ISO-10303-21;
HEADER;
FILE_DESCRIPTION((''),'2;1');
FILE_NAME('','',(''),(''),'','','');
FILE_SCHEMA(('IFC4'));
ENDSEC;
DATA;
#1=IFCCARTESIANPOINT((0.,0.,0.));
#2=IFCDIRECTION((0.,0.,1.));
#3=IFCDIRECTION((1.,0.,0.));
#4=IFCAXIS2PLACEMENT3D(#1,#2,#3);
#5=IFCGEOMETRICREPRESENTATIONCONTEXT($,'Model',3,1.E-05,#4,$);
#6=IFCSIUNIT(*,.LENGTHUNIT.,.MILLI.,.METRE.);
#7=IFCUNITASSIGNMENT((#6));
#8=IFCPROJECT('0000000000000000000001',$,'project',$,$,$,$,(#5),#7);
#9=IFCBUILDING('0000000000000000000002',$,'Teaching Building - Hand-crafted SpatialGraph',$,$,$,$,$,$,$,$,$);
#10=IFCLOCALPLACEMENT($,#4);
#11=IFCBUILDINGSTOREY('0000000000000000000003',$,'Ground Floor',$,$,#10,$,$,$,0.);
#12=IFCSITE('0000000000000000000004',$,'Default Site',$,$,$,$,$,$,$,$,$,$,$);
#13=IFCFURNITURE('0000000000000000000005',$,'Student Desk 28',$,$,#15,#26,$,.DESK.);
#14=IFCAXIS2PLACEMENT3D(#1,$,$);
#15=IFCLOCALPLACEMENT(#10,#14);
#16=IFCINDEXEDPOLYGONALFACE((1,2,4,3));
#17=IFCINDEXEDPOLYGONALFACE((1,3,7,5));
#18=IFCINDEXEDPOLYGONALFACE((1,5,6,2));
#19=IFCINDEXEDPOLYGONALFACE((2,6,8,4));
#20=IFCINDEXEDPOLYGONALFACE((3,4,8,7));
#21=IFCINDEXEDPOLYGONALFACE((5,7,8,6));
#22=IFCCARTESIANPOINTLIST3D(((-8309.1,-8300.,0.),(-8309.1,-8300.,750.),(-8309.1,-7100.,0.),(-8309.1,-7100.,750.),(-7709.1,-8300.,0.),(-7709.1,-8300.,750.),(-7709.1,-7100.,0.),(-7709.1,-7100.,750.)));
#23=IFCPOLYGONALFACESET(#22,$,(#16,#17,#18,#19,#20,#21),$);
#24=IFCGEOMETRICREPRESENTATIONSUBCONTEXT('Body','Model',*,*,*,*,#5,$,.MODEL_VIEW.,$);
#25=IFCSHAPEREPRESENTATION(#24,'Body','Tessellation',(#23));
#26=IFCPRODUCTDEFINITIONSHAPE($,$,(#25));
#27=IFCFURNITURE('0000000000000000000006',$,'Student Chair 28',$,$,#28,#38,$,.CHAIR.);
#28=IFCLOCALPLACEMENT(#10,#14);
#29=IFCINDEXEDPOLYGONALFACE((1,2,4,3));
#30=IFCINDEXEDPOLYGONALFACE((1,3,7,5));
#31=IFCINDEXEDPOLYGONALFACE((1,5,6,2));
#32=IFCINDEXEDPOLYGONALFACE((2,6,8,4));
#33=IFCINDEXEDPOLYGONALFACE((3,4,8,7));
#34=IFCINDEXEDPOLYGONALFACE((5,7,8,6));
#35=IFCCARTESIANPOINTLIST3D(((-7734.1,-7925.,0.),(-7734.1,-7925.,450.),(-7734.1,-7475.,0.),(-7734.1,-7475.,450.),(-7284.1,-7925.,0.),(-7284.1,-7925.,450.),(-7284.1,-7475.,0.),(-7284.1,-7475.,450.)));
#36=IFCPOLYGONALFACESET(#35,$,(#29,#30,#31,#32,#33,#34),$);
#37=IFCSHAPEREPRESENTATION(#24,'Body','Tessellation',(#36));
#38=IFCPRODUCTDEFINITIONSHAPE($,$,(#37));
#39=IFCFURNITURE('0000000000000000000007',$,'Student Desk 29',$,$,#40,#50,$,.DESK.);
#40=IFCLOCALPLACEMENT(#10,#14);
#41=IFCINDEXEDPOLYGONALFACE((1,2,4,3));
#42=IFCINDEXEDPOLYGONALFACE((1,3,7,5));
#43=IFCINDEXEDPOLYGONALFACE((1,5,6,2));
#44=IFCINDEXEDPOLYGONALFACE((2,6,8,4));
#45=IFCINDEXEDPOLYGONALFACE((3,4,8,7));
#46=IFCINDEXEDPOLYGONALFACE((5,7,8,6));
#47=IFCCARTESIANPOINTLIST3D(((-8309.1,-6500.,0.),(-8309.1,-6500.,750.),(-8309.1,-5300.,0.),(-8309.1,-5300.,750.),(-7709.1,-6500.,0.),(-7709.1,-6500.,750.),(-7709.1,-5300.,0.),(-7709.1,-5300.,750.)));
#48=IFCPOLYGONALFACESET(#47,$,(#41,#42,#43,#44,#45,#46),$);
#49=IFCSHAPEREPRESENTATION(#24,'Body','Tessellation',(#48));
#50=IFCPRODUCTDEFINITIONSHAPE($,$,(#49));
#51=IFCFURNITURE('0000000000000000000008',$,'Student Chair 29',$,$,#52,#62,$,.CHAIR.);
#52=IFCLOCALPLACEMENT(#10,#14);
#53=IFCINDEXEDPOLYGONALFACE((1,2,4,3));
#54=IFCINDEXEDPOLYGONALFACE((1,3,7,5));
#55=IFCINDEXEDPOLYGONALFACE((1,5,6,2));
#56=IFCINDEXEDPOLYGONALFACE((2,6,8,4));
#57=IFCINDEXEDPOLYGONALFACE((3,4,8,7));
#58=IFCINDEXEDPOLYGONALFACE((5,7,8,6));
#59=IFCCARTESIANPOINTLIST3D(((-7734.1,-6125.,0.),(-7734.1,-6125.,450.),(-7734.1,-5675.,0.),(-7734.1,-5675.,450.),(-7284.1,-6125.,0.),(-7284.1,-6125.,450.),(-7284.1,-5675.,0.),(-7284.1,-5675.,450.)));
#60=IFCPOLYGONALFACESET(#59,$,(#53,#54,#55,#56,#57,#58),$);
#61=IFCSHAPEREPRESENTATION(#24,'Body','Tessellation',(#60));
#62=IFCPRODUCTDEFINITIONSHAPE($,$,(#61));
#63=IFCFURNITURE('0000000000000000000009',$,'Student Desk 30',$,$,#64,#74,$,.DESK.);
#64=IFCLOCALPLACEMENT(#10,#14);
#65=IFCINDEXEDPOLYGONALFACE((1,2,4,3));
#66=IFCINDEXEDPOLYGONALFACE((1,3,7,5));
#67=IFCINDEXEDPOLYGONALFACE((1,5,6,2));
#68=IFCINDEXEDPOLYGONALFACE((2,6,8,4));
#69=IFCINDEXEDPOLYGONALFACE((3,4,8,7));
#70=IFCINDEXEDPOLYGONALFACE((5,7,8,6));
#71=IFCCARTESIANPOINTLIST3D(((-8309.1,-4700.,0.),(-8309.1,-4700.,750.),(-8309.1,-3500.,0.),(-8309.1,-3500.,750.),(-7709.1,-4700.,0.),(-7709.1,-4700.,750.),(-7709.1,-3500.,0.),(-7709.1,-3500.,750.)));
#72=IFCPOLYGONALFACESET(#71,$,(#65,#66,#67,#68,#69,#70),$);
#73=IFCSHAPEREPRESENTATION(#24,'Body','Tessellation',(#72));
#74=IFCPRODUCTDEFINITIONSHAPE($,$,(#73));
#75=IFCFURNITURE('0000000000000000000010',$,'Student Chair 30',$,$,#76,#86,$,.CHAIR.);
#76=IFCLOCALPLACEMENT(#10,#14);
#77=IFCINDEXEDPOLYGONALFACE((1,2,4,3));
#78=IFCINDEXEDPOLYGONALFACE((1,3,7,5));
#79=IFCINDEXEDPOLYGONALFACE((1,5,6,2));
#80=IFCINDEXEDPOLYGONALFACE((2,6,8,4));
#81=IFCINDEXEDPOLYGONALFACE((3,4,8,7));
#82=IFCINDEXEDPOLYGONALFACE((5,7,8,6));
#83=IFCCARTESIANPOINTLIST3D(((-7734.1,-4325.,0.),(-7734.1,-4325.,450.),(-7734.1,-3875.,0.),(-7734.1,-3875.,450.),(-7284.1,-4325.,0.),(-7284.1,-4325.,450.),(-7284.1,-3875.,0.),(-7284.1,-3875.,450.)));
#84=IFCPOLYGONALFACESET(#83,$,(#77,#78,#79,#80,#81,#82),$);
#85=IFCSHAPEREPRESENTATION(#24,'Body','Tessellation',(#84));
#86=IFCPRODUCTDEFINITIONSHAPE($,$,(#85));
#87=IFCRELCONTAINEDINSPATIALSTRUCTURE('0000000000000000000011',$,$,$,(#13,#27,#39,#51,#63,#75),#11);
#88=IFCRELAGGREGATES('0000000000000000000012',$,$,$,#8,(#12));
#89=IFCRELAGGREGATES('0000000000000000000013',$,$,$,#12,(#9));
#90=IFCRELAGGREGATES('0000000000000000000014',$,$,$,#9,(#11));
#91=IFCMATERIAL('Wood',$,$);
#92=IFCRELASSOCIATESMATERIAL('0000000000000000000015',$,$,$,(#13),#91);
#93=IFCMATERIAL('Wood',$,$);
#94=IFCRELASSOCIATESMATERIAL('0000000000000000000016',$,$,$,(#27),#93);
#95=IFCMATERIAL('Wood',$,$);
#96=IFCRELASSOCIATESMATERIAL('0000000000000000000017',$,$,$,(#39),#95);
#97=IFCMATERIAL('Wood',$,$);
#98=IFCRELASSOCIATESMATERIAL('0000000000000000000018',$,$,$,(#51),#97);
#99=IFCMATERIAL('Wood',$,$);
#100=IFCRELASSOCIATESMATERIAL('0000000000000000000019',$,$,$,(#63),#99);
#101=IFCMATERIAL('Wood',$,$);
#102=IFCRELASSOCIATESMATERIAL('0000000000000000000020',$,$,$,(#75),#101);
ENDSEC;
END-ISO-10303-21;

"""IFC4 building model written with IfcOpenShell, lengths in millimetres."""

from ifc_helpers import new_model, si_unit, frame, origin_with_axes, origin_2d, place, context, subcontext, project, spatial, rectangle, extrude, material, element, save


model = new_model("IFC4")

# Units and contexts
model_context = context("Model", 3, precision=1e-05, world=origin_with_axes())
body_context = subcontext(model_context, "Body", "Model", "MODEL_VIEW")
ifc_project = project(units=[si_unit("LENGTHUNIT", "METRE", prefix="MILLI")], contexts=[model_context])

# Site, building, storey
site = spatial("IfcSite", under=ifc_project, Name="Default Site")
building = spatial("IfcBuilding", under=site, Name="Teaching Building - Hand-crafted SpatialGraph")
storey_placement = place(None, origin_with_axes())
storey = spatial("IfcBuildingStorey", under=building, at=storey_placement, Name="Ground Floor", Elevation=0.0)

# Furniture
ifc_material_1 = material(Name="Wood")
furniture_1_placement = place(storey_placement, frame((-8009.1, -7700.0, 0.0), z_axis=(0.0, 0.0, 1.0), x_axis=(0.0, 1.0, 0.0)))
element("IfcFurniture", 1, at=furniture_1_placement, inside=storey, material=ifc_material_1, Name="Student Desk 28", PredefinedType="DESK", context=body_context, shape_type="SweptSolid", body=[
    extrude(rectangle(XDim=1200.0, YDim=600.0, at=origin_2d()), origin_with_axes(), (0.0, 0.0, 1.0), 750.0),
])
ifc_material_2 = material(Name="Wood")
furniture_2_placement = place(storey_placement, frame((-7509.1, -7700.0, 0.0), z_axis=(0.0, 0.0, 1.0), x_axis=(1.0, 0.0, 0.0)))
element("IfcFurniture", 2, at=furniture_2_placement, inside=storey, material=ifc_material_2, Name="Student Chair 28", PredefinedType="CHAIR", context=body_context, shape_type="SweptSolid", body=[
    extrude(rectangle(XDim=450.0, YDim=450.0, at=origin_2d()), origin_with_axes(), (0.0, 0.0, 1.0), 450.0),
])
ifc_material_3 = material(Name="Wood")
furniture_3_placement = place(storey_placement, frame((-8009.1, -5900.0, 0.0), z_axis=(0.0, 0.0, 1.0), x_axis=(0.0, 1.0, 0.0)))
element("IfcFurniture", 3, at=furniture_3_placement, inside=storey, material=ifc_material_3, Name="Student Desk 29", PredefinedType="DESK", context=body_context, shape_type="SweptSolid", body=[
    extrude(rectangle(XDim=1200.0, YDim=600.0, at=origin_2d()), origin_with_axes(), (0.0, 0.0, 1.0), 750.0),
])
ifc_material_4 = material(Name="Wood")
furniture_4_placement = place(storey_placement, frame((-7509.1, -5900.0, 0.0), z_axis=(0.0, 0.0, 1.0), x_axis=(1.0, 0.0, 0.0)))
element("IfcFurniture", 4, at=furniture_4_placement, inside=storey, material=ifc_material_4, Name="Student Chair 29", PredefinedType="CHAIR", context=body_context, shape_type="SweptSolid", body=[
    extrude(rectangle(XDim=450.0, YDim=450.0, at=origin_2d()), origin_with_axes(), (0.0, 0.0, 1.0), 450.0),
])
ifc_material_5 = material(Name="Wood")
furniture_5_placement = place(storey_placement, frame((-8009.1, -4100.0, 0.0), z_axis=(0.0, 0.0, 1.0), x_axis=(0.0, 1.0, 0.0)))
element("IfcFurniture", 5, at=furniture_5_placement, inside=storey, material=ifc_material_5, Name="Student Desk 30", PredefinedType="DESK", context=body_context, shape_type="SweptSolid", body=[
    extrude(rectangle(XDim=1200.0, YDim=600.0, at=origin_2d()), origin_with_axes(), (0.0, 0.0, 1.0), 750.0),
])
ifc_material_6 = material(Name="Wood")
furniture_6_placement = place(storey_placement, frame((-7509.1, -4100.0, 0.0), z_axis=(0.0, 0.0, 1.0), x_axis=(1.0, 0.0, 0.0)))
element("IfcFurniture", 6, at=furniture_6_placement, inside=storey, material=ifc_material_6, Name="Student Chair 30", PredefinedType="CHAIR", context=body_context, shape_type="SweptSolid", body=[
    extrude(rectangle(XDim=450.0, YDim=450.0, at=origin_2d()), origin_with_axes(), (0.0, 0.0, 1.0), 450.0),
])

save(model, "model.ifc")
